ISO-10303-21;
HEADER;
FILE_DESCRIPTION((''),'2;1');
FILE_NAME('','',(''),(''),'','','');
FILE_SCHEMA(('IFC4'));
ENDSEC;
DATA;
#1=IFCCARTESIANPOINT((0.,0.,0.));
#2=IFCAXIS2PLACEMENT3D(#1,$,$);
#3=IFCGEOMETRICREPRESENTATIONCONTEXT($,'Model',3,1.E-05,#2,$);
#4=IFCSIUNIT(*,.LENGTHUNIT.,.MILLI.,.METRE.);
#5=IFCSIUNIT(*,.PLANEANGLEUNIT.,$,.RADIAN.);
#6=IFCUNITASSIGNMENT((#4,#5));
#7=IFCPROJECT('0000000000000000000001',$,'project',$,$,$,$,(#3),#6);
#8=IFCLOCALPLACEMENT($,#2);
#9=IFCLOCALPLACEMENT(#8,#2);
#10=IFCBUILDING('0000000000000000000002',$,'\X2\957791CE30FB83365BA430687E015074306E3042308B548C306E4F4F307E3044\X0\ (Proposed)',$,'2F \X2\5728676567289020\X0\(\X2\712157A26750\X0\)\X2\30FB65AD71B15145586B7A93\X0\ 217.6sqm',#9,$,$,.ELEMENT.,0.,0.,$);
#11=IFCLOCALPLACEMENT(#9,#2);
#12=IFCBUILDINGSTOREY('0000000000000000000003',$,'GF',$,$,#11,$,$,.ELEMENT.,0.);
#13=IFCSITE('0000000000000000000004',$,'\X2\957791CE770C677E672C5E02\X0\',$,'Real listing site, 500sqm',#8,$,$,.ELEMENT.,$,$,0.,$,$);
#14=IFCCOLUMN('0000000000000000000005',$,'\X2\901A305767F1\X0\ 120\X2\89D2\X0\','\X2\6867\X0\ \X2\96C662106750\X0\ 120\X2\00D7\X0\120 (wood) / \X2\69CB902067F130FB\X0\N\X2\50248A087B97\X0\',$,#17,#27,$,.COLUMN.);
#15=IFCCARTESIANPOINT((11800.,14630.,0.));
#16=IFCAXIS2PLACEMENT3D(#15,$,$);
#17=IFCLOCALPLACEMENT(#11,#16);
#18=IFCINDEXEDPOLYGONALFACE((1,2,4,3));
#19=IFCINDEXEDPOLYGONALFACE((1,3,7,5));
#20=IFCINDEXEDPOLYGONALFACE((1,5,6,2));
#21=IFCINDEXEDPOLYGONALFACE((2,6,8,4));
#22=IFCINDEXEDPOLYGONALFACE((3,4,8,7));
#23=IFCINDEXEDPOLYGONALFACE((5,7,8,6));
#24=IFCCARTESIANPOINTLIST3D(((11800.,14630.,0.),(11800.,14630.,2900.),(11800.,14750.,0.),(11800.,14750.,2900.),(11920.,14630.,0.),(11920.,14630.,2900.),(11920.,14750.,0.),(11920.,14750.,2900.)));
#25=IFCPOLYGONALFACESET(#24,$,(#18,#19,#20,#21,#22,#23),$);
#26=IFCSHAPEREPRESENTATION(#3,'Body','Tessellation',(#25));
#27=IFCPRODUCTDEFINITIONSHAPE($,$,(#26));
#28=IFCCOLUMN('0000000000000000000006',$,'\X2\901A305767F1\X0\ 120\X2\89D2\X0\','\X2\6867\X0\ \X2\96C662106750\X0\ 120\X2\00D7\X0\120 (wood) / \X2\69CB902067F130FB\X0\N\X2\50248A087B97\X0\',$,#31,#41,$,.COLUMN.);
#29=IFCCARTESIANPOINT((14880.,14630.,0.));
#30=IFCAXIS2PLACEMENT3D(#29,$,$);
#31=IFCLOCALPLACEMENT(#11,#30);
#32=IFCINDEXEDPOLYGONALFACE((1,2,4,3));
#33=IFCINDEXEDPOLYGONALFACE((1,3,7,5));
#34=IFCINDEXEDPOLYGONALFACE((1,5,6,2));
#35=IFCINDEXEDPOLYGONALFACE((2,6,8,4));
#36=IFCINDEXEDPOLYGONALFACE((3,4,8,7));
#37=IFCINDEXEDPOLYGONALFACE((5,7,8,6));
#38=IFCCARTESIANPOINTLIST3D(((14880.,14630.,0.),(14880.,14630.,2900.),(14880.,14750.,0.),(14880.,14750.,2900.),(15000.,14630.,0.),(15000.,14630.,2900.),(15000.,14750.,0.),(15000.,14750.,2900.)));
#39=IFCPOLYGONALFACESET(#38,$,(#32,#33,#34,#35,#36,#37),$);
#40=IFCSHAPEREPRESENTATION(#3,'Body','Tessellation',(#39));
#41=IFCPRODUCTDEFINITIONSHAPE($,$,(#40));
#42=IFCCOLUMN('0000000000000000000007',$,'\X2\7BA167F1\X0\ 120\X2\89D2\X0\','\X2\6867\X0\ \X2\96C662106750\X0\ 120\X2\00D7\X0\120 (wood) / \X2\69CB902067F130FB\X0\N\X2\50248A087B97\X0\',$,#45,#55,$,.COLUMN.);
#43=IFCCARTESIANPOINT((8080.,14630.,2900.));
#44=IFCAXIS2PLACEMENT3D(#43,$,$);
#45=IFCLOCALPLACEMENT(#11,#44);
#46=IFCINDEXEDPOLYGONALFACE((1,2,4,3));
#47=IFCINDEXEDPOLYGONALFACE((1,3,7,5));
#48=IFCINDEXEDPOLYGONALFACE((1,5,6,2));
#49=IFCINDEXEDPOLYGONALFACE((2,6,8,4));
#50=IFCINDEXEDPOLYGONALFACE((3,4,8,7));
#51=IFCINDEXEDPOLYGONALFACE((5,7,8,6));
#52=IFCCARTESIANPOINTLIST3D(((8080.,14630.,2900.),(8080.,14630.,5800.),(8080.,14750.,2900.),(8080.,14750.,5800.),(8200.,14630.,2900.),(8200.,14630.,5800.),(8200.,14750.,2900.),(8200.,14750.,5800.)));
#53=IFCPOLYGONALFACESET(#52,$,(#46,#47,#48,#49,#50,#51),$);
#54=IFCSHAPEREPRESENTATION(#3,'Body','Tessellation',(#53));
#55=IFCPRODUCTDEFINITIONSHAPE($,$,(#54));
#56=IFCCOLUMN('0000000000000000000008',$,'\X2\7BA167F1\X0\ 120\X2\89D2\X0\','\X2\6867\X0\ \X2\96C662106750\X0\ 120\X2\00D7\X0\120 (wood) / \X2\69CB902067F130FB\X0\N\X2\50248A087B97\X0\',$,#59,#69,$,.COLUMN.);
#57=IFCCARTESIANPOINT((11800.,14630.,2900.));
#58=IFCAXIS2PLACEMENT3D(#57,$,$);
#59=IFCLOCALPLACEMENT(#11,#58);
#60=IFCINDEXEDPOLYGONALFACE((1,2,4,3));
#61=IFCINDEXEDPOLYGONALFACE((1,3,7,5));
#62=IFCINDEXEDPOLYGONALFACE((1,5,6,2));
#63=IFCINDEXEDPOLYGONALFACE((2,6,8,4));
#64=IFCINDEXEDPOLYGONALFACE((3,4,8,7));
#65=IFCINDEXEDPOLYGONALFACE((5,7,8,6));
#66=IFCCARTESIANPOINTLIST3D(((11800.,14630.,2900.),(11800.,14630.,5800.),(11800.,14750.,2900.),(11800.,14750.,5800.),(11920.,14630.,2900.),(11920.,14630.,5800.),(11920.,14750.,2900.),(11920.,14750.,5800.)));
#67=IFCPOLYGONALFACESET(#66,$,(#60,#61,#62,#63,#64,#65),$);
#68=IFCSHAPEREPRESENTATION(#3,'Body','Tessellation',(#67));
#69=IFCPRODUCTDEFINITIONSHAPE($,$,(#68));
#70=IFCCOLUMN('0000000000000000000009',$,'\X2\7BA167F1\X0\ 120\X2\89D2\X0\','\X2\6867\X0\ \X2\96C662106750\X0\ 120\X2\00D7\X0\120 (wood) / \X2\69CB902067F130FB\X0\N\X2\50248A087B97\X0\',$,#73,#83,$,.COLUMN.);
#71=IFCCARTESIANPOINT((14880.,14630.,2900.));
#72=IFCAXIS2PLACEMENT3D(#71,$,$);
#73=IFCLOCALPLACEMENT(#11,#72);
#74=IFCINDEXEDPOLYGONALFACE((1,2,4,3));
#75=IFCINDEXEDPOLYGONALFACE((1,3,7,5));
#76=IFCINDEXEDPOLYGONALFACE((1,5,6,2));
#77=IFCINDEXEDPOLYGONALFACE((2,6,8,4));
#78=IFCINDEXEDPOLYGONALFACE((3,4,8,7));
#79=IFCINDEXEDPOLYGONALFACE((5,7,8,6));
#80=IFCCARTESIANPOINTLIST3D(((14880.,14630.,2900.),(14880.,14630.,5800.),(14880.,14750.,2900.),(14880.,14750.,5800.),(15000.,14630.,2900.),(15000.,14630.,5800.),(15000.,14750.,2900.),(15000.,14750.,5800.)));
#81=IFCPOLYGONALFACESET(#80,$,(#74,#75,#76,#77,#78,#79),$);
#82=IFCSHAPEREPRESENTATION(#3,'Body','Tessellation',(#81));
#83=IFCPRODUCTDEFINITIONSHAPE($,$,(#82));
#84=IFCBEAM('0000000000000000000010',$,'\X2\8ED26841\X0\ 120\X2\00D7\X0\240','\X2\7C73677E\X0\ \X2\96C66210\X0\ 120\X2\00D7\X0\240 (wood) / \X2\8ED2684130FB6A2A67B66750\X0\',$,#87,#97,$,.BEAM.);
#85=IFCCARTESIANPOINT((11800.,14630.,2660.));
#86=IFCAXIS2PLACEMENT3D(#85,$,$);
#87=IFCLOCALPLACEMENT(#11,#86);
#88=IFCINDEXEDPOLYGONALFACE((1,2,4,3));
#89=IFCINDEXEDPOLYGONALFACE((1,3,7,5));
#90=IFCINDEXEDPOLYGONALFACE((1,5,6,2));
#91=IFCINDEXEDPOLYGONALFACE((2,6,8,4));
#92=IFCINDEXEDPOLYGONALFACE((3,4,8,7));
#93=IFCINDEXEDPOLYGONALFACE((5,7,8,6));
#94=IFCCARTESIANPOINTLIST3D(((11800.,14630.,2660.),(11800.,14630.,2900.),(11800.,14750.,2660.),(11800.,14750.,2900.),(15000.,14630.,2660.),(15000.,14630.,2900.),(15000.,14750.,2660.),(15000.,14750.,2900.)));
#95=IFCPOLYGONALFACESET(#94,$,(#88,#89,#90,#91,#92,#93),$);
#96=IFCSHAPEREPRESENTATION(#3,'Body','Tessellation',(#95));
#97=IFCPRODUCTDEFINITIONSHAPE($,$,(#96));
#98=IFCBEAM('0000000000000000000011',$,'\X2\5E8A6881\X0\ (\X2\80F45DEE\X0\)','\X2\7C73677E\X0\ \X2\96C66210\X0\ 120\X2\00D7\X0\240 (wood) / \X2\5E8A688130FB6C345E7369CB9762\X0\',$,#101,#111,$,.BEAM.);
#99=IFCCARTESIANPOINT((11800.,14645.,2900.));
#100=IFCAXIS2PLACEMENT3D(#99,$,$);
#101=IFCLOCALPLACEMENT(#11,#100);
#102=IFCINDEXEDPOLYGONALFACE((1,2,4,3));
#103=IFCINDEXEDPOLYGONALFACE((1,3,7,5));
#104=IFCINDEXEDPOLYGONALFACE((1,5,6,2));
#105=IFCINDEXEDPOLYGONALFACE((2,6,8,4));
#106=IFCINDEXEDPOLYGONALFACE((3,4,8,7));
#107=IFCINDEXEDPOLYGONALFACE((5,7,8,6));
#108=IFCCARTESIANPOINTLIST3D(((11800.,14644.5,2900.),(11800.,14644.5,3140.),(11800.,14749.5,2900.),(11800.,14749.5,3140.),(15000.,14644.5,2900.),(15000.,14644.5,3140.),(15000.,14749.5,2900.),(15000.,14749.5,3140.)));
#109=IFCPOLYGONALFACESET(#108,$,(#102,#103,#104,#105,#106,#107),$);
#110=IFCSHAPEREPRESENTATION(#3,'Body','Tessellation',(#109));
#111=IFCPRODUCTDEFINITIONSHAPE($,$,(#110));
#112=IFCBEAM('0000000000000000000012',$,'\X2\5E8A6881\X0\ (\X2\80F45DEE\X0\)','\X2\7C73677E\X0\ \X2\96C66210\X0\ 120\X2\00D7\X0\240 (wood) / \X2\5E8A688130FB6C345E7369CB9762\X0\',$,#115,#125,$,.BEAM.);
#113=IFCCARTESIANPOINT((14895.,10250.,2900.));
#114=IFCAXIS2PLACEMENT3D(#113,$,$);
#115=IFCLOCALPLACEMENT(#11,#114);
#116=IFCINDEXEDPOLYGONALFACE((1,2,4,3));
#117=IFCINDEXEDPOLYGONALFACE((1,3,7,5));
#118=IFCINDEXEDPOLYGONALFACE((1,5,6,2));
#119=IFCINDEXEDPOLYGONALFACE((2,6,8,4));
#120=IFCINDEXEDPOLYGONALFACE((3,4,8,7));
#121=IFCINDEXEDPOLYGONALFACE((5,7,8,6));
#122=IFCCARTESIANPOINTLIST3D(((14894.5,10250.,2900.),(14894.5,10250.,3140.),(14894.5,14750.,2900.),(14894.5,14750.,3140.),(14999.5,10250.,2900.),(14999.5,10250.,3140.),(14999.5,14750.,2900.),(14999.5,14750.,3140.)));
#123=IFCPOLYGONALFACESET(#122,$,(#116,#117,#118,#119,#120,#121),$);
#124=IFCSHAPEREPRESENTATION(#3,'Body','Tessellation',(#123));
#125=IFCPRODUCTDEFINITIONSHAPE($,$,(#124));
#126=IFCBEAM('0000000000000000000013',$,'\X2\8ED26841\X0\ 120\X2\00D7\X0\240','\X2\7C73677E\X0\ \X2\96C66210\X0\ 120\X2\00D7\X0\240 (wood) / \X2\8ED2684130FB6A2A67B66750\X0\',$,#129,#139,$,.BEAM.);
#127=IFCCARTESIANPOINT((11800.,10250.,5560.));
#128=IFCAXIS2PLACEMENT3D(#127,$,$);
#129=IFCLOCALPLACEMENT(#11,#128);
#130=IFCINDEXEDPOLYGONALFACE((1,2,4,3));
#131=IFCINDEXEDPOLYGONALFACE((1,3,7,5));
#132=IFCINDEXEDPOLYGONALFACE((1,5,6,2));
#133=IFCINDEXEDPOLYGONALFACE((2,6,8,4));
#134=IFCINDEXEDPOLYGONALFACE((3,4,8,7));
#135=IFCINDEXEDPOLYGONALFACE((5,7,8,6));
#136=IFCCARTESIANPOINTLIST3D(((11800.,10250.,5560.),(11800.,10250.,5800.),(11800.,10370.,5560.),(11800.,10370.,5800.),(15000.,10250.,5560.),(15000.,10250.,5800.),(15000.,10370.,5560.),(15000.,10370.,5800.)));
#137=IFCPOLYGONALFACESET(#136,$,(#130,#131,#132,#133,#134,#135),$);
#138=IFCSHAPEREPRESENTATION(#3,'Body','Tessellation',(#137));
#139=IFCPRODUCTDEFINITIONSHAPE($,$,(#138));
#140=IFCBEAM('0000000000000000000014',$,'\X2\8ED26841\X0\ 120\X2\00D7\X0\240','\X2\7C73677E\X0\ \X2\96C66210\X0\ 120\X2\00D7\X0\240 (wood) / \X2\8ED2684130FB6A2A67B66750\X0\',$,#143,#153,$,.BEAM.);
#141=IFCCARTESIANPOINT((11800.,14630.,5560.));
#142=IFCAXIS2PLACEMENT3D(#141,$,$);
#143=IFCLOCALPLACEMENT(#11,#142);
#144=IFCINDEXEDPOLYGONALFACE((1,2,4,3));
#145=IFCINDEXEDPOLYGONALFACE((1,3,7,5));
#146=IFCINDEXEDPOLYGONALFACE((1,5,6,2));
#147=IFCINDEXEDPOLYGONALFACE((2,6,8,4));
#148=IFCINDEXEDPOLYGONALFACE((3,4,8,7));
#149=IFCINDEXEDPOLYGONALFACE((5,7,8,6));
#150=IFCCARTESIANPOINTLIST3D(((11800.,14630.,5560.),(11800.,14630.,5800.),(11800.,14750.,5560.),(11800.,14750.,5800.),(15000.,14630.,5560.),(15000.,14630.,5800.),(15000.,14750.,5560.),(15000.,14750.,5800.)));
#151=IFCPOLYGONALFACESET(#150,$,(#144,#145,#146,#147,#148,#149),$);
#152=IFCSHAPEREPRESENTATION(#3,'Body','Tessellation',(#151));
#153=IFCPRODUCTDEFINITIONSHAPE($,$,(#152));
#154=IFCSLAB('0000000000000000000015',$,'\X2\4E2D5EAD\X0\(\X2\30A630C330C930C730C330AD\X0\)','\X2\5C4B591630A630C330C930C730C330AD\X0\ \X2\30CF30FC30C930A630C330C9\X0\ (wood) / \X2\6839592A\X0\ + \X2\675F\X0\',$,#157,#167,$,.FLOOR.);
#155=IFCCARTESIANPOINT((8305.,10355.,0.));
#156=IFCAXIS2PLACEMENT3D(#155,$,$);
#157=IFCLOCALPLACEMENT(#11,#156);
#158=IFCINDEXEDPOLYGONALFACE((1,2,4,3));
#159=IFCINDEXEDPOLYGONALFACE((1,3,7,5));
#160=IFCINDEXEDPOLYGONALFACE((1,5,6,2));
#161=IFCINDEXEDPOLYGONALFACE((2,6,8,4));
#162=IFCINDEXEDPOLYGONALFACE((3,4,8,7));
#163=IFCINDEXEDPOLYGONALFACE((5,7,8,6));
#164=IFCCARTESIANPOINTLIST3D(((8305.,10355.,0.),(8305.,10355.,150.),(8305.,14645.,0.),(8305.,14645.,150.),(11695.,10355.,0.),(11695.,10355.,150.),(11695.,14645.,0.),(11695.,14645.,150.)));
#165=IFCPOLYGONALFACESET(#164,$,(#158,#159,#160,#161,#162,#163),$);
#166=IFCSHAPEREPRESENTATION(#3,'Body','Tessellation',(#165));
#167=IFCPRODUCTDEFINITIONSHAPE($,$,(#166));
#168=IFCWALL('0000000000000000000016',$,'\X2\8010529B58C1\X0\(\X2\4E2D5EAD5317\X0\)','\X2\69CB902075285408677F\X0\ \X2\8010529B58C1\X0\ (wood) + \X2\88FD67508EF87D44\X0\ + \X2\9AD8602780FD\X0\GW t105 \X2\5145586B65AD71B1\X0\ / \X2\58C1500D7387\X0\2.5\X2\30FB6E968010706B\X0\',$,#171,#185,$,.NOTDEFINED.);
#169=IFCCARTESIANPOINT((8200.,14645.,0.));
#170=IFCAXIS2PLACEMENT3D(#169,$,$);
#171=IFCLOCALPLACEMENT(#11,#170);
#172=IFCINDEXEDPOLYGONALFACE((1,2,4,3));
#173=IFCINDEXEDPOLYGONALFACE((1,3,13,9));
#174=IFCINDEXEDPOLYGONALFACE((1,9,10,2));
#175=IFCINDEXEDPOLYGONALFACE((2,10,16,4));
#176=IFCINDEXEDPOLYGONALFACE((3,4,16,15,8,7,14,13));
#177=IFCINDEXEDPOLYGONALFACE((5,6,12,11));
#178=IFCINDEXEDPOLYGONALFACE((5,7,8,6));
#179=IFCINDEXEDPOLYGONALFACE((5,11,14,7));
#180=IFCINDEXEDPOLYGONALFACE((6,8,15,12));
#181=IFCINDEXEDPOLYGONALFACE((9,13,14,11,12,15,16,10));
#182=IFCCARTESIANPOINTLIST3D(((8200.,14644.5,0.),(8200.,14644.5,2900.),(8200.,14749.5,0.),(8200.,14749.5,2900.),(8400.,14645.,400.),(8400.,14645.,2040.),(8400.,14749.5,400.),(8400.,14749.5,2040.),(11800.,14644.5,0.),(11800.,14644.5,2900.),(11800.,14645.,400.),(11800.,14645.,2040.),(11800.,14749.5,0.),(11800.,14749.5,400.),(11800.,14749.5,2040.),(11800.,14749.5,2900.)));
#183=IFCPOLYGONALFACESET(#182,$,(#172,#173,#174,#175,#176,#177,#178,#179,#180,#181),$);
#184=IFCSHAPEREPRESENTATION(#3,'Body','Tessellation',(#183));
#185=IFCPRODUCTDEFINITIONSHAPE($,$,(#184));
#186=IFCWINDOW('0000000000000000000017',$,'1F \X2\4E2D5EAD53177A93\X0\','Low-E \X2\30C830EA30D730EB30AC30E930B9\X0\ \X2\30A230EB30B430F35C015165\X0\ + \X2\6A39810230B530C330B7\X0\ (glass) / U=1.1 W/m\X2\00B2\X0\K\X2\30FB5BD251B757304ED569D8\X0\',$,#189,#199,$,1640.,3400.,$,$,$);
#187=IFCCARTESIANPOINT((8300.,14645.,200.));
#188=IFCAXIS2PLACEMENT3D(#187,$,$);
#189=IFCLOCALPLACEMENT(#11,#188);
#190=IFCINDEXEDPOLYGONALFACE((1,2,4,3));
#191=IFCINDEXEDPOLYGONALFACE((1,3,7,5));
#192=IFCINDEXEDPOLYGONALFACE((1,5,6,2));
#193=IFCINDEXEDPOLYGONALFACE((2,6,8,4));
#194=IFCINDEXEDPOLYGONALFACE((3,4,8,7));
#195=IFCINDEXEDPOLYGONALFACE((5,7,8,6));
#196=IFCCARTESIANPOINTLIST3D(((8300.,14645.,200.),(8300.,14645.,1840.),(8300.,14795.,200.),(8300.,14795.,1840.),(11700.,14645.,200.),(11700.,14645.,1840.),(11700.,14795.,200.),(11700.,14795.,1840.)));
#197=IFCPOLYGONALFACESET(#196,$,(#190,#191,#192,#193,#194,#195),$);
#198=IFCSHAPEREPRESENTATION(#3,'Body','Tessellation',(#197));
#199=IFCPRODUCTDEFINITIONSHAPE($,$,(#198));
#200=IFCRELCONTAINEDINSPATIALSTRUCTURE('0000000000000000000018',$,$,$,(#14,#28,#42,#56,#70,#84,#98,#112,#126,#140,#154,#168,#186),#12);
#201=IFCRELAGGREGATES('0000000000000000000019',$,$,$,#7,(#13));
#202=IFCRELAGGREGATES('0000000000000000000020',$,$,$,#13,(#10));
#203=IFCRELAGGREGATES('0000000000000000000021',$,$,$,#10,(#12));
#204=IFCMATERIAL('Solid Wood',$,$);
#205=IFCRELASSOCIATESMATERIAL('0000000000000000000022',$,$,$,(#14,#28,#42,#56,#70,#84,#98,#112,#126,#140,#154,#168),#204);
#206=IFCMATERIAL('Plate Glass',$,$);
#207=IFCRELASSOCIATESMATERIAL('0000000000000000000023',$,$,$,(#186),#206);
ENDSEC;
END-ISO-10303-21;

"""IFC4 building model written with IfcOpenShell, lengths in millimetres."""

from ifc_helpers import new_model, si_unit, frame, frame_2d, origin, place, context, project, spatial, rectangle, extrude, material, element, fill, save


model = new_model("IFC4")

# Units and contexts
model_context = context("Model", 3, precision=1e-05, world=origin())
ifc_project = project(units=[si_unit("LENGTHUNIT", "METRE", prefix="MILLI"), si_unit("PLANEANGLEUNIT", "RADIAN")], contexts=[model_context])

# Site, building, storey
site_placement = place(None, origin())
site = spatial("IfcSite", under=ifc_project, at=site_placement, Name="長野県松本市", ObjectType="Real listing site, 500sqm", CompositionType="ELEMENT", RefElevation=0.0)
building_placement = place(site_placement, origin())
building = spatial("IfcBuilding", under=site, at=building_placement, Name="長野・茶室と縁側のある和の住まい (Proposed)", ObjectType="2F 在来木造(無垢材)・断熱充填窓 217.6sqm", CompositionType="ELEMENT", ElevationOfRefHeight=0.0, ElevationOfTerrain=0.0)
storey_placement = place(building_placement, origin())
storey = spatial("IfcBuildingStorey", under=building, at=storey_placement, Name="GF", CompositionType="ELEMENT", Elevation=0.0)

# Columns
ifc_material_1 = material(Name="Solid Wood")
column_1_placement = place(storey_placement, frame((11800.0, 14630.0, 0.0)))
element("IfcColumn", 1, at=column_1_placement, inside=storey, material=ifc_material_1, Name="通し柱 120角", Description="桧 集成材 120×120 (wood) / 構造柱・N値計算", PredefinedType="COLUMN", context=model_context, shape_type="SweptSolid", body=[
    extrude(rectangle(XDim=120.0, YDim=120.0, at=frame_2d((60.0, 60.0))), frame((11800.0, 14630.0, 0.0)), (0.0, 0.0, 1.0), 2900.0),
])
column_2_placement = place(storey_placement, frame((14880.0, 14630.0, 0.0)))
element("IfcColumn", 2, at=column_2_placement, inside=storey, material=ifc_material_1, Name="通し柱 120角", Description="桧 集成材 120×120 (wood) / 構造柱・N値計算", PredefinedType="COLUMN", context=model_context, shape_type="SweptSolid", body=[
    extrude(rectangle(XDim=120.0, YDim=120.0, at=frame_2d((60.0, 60.0))), frame((14880.0, 14630.0, 0.0)), (0.0, 0.0, 1.0), 2900.0),
])
column_3_placement = place(storey_placement, frame((8080.0, 14630.0, 2900.0)))
element("IfcColumn", 3, at=column_3_placement, inside=storey, material=ifc_material_1, Name="管柱 120角", Description="桧 集成材 120×120 (wood) / 構造柱・N値計算", PredefinedType="COLUMN", context=model_context, shape_type="SweptSolid", body=[
    extrude(rectangle(XDim=120.0, YDim=120.0, at=frame_2d((60.0, 60.0))), frame((8080.0, 14630.0, 2900.0)), (0.0, 0.0, 1.0), 2900.0),
])
column_4_placement = place(storey_placement, frame((11800.0, 14630.0, 2900.0)))
element("IfcColumn", 4, at=column_4_placement, inside=storey, material=ifc_material_1, Name="管柱 120角", Description="桧 集成材 120×120 (wood) / 構造柱・N値計算", PredefinedType="COLUMN", context=model_context, shape_type="SweptSolid", body=[
    extrude(rectangle(XDim=120.0, YDim=120.0, at=frame_2d((60.0, 60.0))), frame((11800.0, 14630.0, 2900.0)), (0.0, 0.0, 1.0), 2900.0),
])
column_5_placement = place(storey_placement, frame((14880.0, 14630.0, 2900.0)))
element("IfcColumn", 5, at=column_5_placement, inside=storey, material=ifc_material_1, Name="管柱 120角", Description="桧 集成材 120×120 (wood) / 構造柱・N値計算", PredefinedType="COLUMN", context=model_context, shape_type="SweptSolid", body=[
    extrude(rectangle(XDim=120.0, YDim=120.0, at=frame_2d((60.0, 60.0))), frame((14880.0, 14630.0, 2900.0)), (0.0, 0.0, 1.0), 2900.0),
])

# Beams
beam_1_placement = place(storey_placement, frame((11800.0, 14630.0, 2660.0)))
element("IfcBeam", 6, at=beam_1_placement, inside=storey, material=ifc_material_1, Name="軒桁 120×240", Description="米松 集成 120×240 (wood) / 軒桁・横架材", PredefinedType="BEAM", context=model_context, shape_type="SweptSolid", body=[
    extrude(rectangle(XDim=3200.0, YDim=120.0, at=frame_2d((1600.0, 60.0))), frame((11800.0, 14630.0, 2660.0)), (0.0, 0.0, 1.0), 240.0),
])
beam_2_placement = place(storey_placement, frame((11800.0, 14645.0, 2900.0)))
element("IfcBeam", 7, at=beam_2_placement, inside=storey, material=ifc_material_1, Name="床梁 (胴差)", Description="米松 集成 120×240 (wood) / 床梁・水平構面", PredefinedType="BEAM", context=model_context, shape_type="SweptSolid", body=[
    extrude(rectangle(XDim=3200.0, YDim=105.0, at=frame_2d((1600.0, 52.0))), frame((11800.0, 14645.0, 2900.0)), (0.0, 0.0, 1.0), 240.0),
])
beam_3_placement = place(storey_placement, frame((14895.0, 10250.0, 2900.0)))
element("IfcBeam", 8, at=beam_3_placement, inside=storey, material=ifc_material_1, Name="床梁 (胴差)", Description="米松 集成 120×240 (wood) / 床梁・水平構面", PredefinedType="BEAM", context=model_context, shape_type="SweptSolid", body=[
    extrude(rectangle(XDim=105.0, YDim=4500.0, at=frame_2d((52.0, 2250.0))), frame((14895.0, 10250.0, 2900.0)), (0.0, 0.0, 1.0), 240.0),
])
beam_4_placement = place(storey_placement, frame((11800.0, 10250.0, 5560.0)))
element("IfcBeam", 9, at=beam_4_placement, inside=storey, material=ifc_material_1, Name="軒桁 120×240", Description="米松 集成 120×240 (wood) / 軒桁・横架材", PredefinedType="BEAM", context=model_context, shape_type="SweptSolid", body=[
    extrude(rectangle(XDim=3200.0, YDim=120.0, at=frame_2d((1600.0, 60.0))), frame((11800.0, 10250.0, 5560.0)), (0.0, 0.0, 1.0), 240.0),
])
beam_5_placement = place(storey_placement, frame((11800.0, 14630.0, 5560.0)))
element("IfcBeam", 10, at=beam_5_placement, inside=storey, material=ifc_material_1, Name="軒桁 120×240", Description="米松 集成 120×240 (wood) / 軒桁・横架材", PredefinedType="BEAM", context=model_context, shape_type="SweptSolid", body=[
    extrude(rectangle(XDim=3200.0, YDim=120.0, at=frame_2d((1600.0, 60.0))), frame((11800.0, 14630.0, 5560.0)), (0.0, 0.0, 1.0), 240.0),
])

# Slab
slab_placement = place(storey_placement, frame((8305.0, 10355.0, 0.0)))
element("IfcSlab", 11, at=slab_placement, inside=storey, material=ifc_material_1, Name="中庭(ウッドデッキ)", Description="屋外ウッドデッキ ハードウッド (wood) / 根太 + 束", PredefinedType="FLOOR", context=model_context, shape_type="SweptSolid", body=[
    extrude(rectangle(XDim=3390.0, YDim=4290.0, at=frame_2d((1695.0, 2145.0))), frame((8305.0, 10355.0, 0.0)), (0.0, 0.0, 1.0), 150.0),
])

# Wall, opening, window
wall_1_placement = place(storey_placement, frame((8200.0, 14645.0, 0.0)))
wall_1 = element("IfcWall", 12, at=wall_1_placement, inside=storey, material=ifc_material_1, Name="耐力壁(中庭北)", Description="構造用合板 耐力壁 (wood) + 製材軸組 + 高性能GW t105 充填断熱 / 壁倍率2.5・準耐火", PredefinedType="NOTDEFINED", context=model_context, shape_type="SweptSolid", body=[
    extrude(rectangle(XDim=3600.0, YDim=105.0, at=frame_2d((1800.0, 52.0))), frame((8200.0, 14645.0, 0.0)), (0.0, 0.0, 1.0), 2900.0),
])
opening_1_placement = place(storey_placement, frame((8300.0, 14645.0, 200.0)))
opening_1 = element("IfcOpeningElement", 13, at=opening_1_placement, cuts=wall_1, PredefinedType="NOTDEFINED", context=model_context, shape_type="SweptSolid", body=[
    extrude(rectangle(XDim=3400.0, YDim=150.0, at=frame_2d((1700.0, 75.0))), frame((8300.0, 14645.0, 200.0)), (0.0, 0.0, 1.0), 1640.0),
])
ifc_material_2 = material(Name="Plate Glass")
window_1_placement = place(storey_placement, frame((8300.0, 14645.0, 200.0)))
window_1 = element("IfcWindow", 14, at=window_1_placement, inside=storey, material=ifc_material_2, Name="1F 中庭北窓", Description="Low-E トリプルガラス アルゴン封入 + 樹脂サッシ (glass) / U=1.1 W/m²K・寒冷地仕様", OverallHeight=1640.0, OverallWidth=3400.0, context=model_context, shape_type="SweptSolid", body=[
    extrude(rectangle(XDim=3400.0, YDim=150.0, at=frame_2d((1700.0, 75.0))), frame((8300.0, 14645.0, 200.0)), (0.0, 0.0, 1.0), 1640.0),
])
fill(opening_1, window_1)

save(model, "model.ifc")
